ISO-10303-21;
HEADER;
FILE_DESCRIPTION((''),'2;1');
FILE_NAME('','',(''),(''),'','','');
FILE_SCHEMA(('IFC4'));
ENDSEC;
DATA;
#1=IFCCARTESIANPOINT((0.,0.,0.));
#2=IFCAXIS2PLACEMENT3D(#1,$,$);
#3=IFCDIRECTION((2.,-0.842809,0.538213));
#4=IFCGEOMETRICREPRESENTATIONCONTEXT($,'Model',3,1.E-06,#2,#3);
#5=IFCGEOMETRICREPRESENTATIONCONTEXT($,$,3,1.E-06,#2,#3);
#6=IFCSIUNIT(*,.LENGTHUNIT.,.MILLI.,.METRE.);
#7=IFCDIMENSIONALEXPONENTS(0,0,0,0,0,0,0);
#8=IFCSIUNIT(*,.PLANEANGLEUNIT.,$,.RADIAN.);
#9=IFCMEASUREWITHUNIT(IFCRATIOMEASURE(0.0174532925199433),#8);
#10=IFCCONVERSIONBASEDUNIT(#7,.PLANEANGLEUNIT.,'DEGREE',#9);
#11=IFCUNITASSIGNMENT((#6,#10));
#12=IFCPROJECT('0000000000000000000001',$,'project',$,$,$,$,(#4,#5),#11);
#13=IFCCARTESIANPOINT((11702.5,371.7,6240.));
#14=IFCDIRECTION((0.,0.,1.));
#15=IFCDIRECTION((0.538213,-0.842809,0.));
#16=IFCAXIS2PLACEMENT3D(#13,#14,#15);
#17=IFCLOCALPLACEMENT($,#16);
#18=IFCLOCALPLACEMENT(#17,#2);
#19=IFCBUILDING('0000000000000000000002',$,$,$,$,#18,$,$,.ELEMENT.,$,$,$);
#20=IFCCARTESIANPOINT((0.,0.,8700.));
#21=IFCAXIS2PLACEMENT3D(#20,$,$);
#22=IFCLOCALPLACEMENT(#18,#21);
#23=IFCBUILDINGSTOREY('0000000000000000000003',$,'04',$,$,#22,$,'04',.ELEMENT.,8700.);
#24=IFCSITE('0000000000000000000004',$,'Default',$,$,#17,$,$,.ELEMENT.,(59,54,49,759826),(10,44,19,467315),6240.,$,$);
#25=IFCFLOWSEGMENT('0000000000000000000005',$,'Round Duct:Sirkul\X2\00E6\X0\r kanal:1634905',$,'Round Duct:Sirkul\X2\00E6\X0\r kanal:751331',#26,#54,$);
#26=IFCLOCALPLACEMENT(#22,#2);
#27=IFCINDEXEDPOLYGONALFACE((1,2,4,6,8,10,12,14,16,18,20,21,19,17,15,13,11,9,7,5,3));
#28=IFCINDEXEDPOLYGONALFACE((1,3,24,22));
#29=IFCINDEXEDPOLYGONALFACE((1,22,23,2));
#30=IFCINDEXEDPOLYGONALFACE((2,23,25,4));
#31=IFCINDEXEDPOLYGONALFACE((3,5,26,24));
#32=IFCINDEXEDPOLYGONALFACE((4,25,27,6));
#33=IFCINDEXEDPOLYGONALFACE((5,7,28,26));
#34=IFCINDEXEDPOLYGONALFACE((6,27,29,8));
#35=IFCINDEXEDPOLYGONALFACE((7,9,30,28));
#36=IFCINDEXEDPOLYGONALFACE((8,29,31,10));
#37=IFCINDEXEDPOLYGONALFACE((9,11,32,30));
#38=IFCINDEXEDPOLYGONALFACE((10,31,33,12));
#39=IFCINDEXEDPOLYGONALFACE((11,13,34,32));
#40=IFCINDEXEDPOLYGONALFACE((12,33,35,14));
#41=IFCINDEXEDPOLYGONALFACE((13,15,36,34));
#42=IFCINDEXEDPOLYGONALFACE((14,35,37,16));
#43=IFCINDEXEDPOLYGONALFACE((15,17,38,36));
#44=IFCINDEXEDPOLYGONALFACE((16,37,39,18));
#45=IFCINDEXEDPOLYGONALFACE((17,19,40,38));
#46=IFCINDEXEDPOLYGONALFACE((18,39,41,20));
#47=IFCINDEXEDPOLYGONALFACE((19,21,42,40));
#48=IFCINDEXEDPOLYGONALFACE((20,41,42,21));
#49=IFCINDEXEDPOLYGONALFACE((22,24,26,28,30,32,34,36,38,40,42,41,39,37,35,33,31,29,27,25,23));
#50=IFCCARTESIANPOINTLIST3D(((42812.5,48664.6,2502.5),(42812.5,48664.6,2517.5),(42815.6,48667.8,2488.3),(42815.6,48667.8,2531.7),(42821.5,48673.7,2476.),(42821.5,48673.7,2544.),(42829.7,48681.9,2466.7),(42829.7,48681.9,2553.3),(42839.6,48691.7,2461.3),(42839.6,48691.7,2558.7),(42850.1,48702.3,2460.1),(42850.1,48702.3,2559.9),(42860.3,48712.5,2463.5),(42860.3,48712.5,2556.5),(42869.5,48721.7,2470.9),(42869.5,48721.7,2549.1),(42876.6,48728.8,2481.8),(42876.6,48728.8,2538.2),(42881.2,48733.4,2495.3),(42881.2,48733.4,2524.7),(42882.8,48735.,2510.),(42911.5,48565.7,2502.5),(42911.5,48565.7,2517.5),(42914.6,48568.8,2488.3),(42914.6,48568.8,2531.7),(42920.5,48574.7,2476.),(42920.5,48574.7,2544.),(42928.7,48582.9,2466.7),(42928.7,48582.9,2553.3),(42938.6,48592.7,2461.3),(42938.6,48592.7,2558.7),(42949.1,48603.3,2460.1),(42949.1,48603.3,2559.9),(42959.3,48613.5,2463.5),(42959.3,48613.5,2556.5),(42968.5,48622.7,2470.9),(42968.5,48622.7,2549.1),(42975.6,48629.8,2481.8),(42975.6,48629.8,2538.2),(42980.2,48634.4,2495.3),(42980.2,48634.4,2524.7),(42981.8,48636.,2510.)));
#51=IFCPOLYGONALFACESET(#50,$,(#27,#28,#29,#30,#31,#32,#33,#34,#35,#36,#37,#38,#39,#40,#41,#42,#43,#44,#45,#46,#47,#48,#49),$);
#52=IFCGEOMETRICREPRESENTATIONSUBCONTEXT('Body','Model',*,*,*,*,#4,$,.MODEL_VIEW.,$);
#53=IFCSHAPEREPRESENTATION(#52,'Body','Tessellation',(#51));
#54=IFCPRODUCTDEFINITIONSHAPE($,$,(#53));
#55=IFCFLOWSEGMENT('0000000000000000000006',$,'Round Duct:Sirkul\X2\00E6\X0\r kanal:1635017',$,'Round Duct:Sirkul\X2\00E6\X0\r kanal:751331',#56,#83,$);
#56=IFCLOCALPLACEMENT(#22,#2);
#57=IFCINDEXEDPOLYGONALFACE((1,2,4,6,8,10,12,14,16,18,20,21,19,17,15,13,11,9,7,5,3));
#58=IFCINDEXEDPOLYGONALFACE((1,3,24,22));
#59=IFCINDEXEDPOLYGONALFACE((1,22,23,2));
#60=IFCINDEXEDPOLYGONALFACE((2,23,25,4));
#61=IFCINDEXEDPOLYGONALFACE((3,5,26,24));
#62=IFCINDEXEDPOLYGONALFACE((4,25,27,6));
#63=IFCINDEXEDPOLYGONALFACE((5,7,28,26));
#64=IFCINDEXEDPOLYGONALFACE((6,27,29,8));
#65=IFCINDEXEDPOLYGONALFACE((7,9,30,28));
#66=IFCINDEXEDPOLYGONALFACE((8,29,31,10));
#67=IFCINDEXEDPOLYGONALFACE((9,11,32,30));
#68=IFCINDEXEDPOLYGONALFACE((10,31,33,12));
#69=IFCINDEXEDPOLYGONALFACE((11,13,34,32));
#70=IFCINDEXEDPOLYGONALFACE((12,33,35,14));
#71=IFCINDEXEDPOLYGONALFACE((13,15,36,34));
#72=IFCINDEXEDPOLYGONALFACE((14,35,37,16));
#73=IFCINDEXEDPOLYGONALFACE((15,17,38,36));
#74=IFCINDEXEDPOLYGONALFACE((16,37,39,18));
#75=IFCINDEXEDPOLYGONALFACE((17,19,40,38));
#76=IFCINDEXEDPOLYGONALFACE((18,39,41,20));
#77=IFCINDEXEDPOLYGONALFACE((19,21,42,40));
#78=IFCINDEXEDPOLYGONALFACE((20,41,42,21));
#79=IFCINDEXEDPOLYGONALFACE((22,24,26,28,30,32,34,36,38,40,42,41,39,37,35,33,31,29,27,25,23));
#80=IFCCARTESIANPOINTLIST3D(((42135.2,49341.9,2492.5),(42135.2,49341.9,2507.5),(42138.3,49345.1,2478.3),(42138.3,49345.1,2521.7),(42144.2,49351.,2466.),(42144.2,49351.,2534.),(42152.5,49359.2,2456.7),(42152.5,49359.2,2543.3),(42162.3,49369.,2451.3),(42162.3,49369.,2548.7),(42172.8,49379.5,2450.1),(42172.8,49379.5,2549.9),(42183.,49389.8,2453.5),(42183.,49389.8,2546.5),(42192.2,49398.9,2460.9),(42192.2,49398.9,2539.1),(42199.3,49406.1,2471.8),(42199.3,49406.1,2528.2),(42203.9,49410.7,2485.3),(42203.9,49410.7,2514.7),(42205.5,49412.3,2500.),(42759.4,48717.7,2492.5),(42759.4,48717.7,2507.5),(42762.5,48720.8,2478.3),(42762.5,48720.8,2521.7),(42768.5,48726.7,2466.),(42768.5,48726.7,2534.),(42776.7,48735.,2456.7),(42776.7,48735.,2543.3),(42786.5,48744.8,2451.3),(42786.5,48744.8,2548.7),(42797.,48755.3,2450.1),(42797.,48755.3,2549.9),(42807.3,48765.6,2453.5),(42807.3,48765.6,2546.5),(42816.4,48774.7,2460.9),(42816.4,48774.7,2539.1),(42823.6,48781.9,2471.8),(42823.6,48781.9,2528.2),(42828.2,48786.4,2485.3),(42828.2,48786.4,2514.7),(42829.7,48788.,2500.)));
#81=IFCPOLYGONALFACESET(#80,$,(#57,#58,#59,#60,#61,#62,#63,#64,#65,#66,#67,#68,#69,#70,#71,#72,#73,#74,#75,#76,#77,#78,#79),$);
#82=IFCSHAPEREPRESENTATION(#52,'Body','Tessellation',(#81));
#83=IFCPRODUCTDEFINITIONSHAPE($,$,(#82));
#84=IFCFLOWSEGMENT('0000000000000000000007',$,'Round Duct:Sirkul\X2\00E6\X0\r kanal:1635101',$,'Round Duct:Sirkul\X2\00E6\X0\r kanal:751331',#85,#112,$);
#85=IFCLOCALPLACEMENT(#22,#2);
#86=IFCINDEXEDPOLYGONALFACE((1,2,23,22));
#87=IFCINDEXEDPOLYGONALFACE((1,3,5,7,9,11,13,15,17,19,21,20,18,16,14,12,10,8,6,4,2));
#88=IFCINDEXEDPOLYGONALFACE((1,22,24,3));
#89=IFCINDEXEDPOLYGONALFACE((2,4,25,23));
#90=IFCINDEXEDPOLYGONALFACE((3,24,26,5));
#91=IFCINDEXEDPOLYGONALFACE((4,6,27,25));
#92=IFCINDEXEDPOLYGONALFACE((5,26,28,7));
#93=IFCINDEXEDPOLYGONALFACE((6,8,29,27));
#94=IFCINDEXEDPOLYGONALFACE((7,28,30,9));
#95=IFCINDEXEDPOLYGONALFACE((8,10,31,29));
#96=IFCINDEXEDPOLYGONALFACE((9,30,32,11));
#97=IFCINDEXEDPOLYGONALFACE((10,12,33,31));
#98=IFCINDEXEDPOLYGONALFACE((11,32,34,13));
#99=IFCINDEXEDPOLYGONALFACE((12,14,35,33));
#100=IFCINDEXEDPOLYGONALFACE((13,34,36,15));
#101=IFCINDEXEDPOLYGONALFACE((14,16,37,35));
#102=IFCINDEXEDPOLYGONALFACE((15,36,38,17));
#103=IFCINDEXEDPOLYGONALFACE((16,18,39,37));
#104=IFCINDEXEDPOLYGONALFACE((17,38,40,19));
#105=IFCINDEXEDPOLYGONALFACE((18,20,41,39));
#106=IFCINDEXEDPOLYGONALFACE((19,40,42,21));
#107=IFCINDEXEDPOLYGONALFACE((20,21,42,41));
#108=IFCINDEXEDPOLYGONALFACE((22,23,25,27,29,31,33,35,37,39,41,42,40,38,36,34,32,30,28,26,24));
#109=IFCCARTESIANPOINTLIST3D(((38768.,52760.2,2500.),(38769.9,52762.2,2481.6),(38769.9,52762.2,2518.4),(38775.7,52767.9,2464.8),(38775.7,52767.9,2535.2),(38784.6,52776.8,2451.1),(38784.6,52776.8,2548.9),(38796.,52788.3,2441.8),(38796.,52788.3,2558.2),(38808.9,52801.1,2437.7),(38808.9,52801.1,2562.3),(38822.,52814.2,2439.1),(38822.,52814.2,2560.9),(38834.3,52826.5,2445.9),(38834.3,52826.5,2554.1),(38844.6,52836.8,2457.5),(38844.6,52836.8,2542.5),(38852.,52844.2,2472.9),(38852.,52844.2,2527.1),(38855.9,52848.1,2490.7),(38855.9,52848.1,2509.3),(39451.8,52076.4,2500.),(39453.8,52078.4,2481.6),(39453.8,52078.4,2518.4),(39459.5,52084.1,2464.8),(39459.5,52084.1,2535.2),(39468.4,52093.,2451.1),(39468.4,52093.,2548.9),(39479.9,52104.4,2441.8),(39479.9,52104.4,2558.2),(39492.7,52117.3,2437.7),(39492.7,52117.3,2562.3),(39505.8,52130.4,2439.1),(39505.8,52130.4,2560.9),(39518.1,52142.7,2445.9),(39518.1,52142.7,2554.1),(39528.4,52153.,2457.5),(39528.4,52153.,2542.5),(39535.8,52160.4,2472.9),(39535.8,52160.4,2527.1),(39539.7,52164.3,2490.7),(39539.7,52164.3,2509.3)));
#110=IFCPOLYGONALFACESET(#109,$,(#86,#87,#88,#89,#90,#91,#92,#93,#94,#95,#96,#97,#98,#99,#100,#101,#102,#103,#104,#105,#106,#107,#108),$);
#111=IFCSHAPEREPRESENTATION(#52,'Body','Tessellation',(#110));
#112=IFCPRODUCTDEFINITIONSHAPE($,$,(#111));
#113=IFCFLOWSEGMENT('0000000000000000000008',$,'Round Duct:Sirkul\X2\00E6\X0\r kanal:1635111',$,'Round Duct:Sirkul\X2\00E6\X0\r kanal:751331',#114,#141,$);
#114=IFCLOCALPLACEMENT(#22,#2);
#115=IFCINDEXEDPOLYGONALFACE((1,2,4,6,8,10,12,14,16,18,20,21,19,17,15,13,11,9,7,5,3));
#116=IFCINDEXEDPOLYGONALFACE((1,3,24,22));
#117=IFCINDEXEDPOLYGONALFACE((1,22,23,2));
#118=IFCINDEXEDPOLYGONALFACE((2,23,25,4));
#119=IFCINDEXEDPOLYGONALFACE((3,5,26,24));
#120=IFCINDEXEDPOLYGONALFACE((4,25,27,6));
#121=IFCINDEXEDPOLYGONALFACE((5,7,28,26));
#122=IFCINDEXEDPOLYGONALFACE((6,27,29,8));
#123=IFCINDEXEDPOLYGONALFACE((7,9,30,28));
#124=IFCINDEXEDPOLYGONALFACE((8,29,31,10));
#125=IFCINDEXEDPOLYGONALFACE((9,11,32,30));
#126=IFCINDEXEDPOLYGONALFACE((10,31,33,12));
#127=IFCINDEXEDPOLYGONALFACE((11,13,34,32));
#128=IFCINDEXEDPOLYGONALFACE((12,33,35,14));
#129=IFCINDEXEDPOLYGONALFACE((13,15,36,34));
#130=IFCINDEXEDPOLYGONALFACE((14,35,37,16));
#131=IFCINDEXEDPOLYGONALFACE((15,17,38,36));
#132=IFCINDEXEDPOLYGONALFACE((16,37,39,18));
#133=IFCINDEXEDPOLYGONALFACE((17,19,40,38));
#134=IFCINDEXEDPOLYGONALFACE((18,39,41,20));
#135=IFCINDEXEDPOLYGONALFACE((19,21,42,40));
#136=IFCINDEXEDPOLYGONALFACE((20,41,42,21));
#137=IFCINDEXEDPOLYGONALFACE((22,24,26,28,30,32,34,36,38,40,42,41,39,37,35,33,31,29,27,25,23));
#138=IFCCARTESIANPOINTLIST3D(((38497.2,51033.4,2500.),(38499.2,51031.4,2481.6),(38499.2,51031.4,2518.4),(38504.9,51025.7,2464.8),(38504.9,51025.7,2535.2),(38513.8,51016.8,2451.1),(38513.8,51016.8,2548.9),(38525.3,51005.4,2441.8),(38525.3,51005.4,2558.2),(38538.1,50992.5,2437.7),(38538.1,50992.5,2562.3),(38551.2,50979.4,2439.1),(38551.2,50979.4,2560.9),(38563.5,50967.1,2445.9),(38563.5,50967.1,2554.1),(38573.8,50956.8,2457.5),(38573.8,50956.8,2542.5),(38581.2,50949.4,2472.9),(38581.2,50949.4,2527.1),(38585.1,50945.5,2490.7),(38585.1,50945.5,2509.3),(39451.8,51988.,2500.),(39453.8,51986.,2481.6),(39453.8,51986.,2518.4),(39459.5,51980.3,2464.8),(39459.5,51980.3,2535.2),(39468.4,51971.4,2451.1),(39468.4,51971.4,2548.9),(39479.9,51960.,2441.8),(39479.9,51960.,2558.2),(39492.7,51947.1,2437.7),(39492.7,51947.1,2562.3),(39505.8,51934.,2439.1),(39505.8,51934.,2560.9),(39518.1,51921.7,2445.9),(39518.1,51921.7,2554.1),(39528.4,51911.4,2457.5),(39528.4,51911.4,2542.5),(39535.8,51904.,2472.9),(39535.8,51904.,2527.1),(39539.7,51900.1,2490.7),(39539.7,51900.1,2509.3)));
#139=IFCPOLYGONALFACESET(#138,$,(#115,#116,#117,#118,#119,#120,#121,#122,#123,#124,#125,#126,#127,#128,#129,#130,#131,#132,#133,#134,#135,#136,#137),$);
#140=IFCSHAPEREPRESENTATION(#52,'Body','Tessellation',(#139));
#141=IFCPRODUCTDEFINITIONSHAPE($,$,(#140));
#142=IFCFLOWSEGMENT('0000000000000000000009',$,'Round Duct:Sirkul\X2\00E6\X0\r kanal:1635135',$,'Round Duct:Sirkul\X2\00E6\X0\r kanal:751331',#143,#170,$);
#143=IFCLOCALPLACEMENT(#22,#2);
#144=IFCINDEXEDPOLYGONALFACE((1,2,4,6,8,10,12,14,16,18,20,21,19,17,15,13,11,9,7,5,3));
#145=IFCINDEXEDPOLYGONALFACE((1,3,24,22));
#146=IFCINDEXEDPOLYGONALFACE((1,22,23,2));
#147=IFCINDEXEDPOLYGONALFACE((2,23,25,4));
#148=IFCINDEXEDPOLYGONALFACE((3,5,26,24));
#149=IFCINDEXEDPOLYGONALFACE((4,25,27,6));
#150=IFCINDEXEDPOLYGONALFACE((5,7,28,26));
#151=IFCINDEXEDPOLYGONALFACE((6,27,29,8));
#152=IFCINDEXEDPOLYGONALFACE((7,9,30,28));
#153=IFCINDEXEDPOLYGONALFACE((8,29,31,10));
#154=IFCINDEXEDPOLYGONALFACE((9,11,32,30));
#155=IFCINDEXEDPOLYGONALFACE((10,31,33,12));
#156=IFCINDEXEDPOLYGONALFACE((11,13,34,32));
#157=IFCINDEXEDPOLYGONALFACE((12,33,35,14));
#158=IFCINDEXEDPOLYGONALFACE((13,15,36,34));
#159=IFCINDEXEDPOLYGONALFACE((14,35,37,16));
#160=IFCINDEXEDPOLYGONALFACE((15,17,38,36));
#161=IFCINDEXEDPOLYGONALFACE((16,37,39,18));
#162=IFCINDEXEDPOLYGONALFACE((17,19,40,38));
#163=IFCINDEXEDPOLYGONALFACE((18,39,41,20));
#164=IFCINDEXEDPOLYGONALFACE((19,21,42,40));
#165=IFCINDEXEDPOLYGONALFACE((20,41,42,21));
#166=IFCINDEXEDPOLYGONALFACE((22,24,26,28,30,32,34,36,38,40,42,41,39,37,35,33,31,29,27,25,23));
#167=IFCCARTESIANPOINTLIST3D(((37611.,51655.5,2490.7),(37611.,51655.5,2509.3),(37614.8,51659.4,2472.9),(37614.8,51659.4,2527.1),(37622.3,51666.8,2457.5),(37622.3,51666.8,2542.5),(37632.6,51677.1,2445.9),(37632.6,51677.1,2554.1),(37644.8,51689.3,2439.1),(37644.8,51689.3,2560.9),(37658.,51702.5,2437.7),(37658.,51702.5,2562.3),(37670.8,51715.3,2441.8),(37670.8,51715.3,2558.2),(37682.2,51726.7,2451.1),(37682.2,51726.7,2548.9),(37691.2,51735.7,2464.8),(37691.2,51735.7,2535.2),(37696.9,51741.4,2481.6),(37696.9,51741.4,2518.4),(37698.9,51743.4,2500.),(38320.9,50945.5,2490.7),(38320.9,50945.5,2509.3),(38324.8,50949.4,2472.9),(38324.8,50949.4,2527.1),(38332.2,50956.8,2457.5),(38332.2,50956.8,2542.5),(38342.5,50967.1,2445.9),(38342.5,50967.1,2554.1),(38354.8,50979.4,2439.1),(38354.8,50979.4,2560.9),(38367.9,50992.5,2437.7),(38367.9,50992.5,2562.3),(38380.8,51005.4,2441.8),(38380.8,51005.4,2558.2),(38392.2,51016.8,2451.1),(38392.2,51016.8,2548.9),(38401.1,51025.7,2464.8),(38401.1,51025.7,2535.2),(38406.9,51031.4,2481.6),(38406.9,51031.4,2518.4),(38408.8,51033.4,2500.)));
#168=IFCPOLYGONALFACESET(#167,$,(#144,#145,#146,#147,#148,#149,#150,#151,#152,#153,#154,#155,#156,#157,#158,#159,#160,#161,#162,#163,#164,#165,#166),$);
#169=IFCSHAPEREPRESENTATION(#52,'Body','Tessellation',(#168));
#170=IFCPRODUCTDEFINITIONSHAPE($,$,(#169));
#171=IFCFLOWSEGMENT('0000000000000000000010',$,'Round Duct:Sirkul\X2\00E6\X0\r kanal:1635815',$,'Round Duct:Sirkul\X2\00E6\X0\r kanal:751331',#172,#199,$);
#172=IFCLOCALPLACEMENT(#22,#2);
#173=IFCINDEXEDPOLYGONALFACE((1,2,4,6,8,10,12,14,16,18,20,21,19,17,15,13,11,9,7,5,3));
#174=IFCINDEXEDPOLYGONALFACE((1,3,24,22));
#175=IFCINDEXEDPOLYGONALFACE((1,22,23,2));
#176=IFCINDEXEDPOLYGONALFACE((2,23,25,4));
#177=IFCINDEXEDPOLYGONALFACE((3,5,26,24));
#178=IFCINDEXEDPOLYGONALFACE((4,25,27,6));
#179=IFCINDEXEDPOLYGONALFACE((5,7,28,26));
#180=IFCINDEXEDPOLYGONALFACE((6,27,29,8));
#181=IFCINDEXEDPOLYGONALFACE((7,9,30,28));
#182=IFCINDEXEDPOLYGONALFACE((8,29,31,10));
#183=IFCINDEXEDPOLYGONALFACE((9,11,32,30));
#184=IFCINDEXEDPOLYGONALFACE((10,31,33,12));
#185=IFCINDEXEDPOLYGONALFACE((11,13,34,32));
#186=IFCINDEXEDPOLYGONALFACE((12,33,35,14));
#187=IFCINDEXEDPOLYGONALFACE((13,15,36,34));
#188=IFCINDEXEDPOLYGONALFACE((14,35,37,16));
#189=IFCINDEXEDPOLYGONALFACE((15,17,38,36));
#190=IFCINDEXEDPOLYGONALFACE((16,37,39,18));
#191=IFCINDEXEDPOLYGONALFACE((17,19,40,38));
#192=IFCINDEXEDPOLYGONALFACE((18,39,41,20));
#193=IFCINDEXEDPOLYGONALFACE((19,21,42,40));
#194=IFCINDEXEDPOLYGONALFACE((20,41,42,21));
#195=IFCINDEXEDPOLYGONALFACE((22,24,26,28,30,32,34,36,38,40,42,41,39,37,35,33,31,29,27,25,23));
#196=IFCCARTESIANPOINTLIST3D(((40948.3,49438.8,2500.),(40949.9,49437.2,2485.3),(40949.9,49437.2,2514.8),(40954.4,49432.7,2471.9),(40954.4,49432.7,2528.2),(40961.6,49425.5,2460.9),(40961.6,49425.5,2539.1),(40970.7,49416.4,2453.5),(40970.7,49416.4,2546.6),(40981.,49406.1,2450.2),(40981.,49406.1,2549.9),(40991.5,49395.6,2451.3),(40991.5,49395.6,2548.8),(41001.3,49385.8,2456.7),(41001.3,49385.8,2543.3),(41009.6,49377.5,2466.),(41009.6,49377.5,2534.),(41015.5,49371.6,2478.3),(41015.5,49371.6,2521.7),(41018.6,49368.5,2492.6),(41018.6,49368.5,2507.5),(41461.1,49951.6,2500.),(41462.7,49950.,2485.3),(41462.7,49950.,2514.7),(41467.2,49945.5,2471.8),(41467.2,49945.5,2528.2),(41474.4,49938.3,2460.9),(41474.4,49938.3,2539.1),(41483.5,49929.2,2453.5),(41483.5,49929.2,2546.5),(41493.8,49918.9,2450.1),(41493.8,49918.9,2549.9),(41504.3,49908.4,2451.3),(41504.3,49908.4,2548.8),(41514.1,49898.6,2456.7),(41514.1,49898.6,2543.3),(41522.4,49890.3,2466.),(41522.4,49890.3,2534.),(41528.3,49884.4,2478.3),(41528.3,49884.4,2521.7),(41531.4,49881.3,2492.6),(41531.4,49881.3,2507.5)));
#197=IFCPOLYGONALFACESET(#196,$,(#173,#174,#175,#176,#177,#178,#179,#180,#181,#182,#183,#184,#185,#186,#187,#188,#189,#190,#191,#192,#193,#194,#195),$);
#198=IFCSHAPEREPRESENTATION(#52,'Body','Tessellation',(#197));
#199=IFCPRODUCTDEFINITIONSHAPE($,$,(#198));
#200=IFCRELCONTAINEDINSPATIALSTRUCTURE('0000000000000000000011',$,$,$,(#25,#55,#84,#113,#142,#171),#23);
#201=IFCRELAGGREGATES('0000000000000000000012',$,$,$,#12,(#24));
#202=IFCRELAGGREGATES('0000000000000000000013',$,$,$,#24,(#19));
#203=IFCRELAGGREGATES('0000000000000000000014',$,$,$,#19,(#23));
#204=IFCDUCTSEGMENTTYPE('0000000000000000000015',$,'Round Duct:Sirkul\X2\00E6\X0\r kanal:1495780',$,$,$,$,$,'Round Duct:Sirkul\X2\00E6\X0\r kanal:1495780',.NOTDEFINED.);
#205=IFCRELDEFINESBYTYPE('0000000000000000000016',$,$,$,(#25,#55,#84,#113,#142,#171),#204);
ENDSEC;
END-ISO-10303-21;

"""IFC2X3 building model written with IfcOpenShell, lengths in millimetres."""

from ifc_helpers import new_model, entity, si_unit, converted_unit, direction, frame, frame_2d, origin, origin_2d_with_axis, place, context, subcontext, project, spatial, circle, extrude, type_object, element, save


model = new_model("IFC2X3")

# Units and contexts
model_context = context("Model", 3, precision=1e-06, world=origin(), true_north=direction((2.0, -0.842809, 0.538213)))
context_of_model = context(None, 3, precision=1e-06, world=origin(), true_north=direction((2.0, -0.842809, 0.538213)))
body_context = subcontext(model_context, "Body", "Model", "MODEL_VIEW")
ifc_project = project(units=[si_unit("LENGTHUNIT", "METRE", prefix="MILLI"), converted_unit("PLANEANGLEUNIT", "DEGREE", entity("IfcRatioMeasure", 0.0174532925199433), si_unit("PLANEANGLEUNIT", "RADIAN"), dimensions=[0, 0, 0, 0, 0, 0, 0])], contexts=[model_context, context_of_model])

# Site, building, storey
site_placement = place(None, frame((11702.5, 371.7, 6240.0), z_axis=(0.0, 0.0, 1.0), x_axis=(0.538213, -0.842809, 0.0)))
site = spatial("IfcSite", under=ifc_project, at=site_placement, Name="Default", CompositionType="ELEMENT", RefLatitude=(59, 54, 49, 759826), RefLongitude=(10, 44, 19, 467315), RefElevation=6240.0)
building_placement = place(site_placement, origin())
building = spatial("IfcBuilding", under=site, at=building_placement, CompositionType="ELEMENT")
storey_placement = place(building_placement, frame((0.0, 0.0, 8700.0)))
storey = spatial("IfcBuildingStorey", under=building, at=storey_placement, Name="04", LongName="04", CompositionType="ELEMENT", Elevation=8700.0)

# Flow segments
duct_segment_type = type_object("IfcDuctSegmentType", Name="Round Duct:Sirkulær kanal:1495780", ElementType="Round Duct:Sirkulær kanal:1495780", PredefinedType="NOTDEFINED")
flow_segment_1_placement = place(storey_placement, origin())
element("IfcFlowSegment", 1, at=flow_segment_1_placement, inside=storey, type_object=duct_segment_type, Name="Round Duct:Sirkulær kanal:1634905", ObjectType="Round Duct:Sirkulær kanal:751331", context=body_context, shape_type="SweptSolid", body=[
    extrude(circle(Radius=50.0, at=frame_2d((0.0, 0.0), x_axis=(1.0, 0.0))), frame((42847.4, 48699.6, 2510.0), z_axis=(0.707107, -0.707107, 0.0), x_axis=(0.707107, 0.707107, 0.0)), (0.0, 0.0, 1.0), 140.0),
])
flow_segment_2_placement = place(storey_placement, origin())
element("IfcFlowSegment", 2, at=flow_segment_2_placement, inside=storey, type_object=duct_segment_type, Name="Round Duct:Sirkulær kanal:1635017", ObjectType="Round Duct:Sirkulær kanal:751331", context=body_context, shape_type="SweptSolid", body=[
    extrude(circle(Radius=50.0, at=origin_2d_with_axis()), frame((42794.4, 48752.6, 2500.0), z_axis=(-0.707107, 0.707107, 0.0), x_axis=(0.707107, 0.707107, 0.0)), (0.0, 0.0, 1.0), 882.8),
])
flow_segment_3_placement = place(storey_placement, origin())
element("IfcFlowSegment", 3, at=flow_segment_3_placement, inside=storey, type_object=duct_segment_type, Name="Round Duct:Sirkulær kanal:1635101", ObjectType="Round Duct:Sirkulær kanal:751331", context=body_context, shape_type="SweptSolid", body=[
    extrude(circle(Radius=62.5, at=origin_2d_with_axis()), frame((39496.0, 52120.6, 2500.0), z_axis=(-0.707107, 0.707107, 0.0), x_axis=(-0.707107, -0.707107, 0.0)), (0.0, 0.0, 1.0), 967.1),
])
flow_segment_4_placement = place(storey_placement, origin())
element("IfcFlowSegment", 4, at=flow_segment_4_placement, inside=storey, type_object=duct_segment_type, Name="Round Duct:Sirkulær kanal:1635111", ObjectType="Round Duct:Sirkulær kanal:751331", context=body_context, shape_type="SweptSolid", body=[
    extrude(circle(Radius=62.5, at=origin_2d_with_axis()), frame((38541.4, 50989.2, 2500.0), z_axis=(0.707107, 0.707107, 0.0), x_axis=(-0.707107, 0.707107, 0.0)), (0.0, 0.0, 1.0), 1350.0),
])
flow_segment_5_placement = place(storey_placement, origin())
element("IfcFlowSegment", 5, at=flow_segment_5_placement, inside=storey, type_object=duct_segment_type, Name="Round Duct:Sirkulær kanal:1635135", ObjectType="Round Duct:Sirkulær kanal:751331", context=body_context, shape_type="SweptSolid", body=[
    extrude(circle(Radius=62.5, at=origin_2d_with_axis()), frame((38364.6, 50989.2, 2500.0), z_axis=(-0.707107, 0.707107, 0.0), x_axis=(0.707107, 0.707107, 0.0)), (0.0, 0.0, 1.0), 1004.0),
])
flow_segment_6_placement = place(storey_placement, origin())
element("IfcFlowSegment", 6, at=flow_segment_6_placement, inside=storey, type_object=duct_segment_type, Name="Round Duct:Sirkulær kanal:1635815", ObjectType="Round Duct:Sirkulær kanal:751331", context=body_context, shape_type="SweptSolid", body=[
    extrude(circle(Radius=50.0, at=origin_2d_with_axis()), frame((41496.4, 49916.2, 2500.0), z_axis=(-0.707107, -0.707107, 0.000045), x_axis=(-0.707107, 0.707107, 0.0)), (0.0, 0.0, 1.0), 725.2),
])

save(model, "model.ifc")
